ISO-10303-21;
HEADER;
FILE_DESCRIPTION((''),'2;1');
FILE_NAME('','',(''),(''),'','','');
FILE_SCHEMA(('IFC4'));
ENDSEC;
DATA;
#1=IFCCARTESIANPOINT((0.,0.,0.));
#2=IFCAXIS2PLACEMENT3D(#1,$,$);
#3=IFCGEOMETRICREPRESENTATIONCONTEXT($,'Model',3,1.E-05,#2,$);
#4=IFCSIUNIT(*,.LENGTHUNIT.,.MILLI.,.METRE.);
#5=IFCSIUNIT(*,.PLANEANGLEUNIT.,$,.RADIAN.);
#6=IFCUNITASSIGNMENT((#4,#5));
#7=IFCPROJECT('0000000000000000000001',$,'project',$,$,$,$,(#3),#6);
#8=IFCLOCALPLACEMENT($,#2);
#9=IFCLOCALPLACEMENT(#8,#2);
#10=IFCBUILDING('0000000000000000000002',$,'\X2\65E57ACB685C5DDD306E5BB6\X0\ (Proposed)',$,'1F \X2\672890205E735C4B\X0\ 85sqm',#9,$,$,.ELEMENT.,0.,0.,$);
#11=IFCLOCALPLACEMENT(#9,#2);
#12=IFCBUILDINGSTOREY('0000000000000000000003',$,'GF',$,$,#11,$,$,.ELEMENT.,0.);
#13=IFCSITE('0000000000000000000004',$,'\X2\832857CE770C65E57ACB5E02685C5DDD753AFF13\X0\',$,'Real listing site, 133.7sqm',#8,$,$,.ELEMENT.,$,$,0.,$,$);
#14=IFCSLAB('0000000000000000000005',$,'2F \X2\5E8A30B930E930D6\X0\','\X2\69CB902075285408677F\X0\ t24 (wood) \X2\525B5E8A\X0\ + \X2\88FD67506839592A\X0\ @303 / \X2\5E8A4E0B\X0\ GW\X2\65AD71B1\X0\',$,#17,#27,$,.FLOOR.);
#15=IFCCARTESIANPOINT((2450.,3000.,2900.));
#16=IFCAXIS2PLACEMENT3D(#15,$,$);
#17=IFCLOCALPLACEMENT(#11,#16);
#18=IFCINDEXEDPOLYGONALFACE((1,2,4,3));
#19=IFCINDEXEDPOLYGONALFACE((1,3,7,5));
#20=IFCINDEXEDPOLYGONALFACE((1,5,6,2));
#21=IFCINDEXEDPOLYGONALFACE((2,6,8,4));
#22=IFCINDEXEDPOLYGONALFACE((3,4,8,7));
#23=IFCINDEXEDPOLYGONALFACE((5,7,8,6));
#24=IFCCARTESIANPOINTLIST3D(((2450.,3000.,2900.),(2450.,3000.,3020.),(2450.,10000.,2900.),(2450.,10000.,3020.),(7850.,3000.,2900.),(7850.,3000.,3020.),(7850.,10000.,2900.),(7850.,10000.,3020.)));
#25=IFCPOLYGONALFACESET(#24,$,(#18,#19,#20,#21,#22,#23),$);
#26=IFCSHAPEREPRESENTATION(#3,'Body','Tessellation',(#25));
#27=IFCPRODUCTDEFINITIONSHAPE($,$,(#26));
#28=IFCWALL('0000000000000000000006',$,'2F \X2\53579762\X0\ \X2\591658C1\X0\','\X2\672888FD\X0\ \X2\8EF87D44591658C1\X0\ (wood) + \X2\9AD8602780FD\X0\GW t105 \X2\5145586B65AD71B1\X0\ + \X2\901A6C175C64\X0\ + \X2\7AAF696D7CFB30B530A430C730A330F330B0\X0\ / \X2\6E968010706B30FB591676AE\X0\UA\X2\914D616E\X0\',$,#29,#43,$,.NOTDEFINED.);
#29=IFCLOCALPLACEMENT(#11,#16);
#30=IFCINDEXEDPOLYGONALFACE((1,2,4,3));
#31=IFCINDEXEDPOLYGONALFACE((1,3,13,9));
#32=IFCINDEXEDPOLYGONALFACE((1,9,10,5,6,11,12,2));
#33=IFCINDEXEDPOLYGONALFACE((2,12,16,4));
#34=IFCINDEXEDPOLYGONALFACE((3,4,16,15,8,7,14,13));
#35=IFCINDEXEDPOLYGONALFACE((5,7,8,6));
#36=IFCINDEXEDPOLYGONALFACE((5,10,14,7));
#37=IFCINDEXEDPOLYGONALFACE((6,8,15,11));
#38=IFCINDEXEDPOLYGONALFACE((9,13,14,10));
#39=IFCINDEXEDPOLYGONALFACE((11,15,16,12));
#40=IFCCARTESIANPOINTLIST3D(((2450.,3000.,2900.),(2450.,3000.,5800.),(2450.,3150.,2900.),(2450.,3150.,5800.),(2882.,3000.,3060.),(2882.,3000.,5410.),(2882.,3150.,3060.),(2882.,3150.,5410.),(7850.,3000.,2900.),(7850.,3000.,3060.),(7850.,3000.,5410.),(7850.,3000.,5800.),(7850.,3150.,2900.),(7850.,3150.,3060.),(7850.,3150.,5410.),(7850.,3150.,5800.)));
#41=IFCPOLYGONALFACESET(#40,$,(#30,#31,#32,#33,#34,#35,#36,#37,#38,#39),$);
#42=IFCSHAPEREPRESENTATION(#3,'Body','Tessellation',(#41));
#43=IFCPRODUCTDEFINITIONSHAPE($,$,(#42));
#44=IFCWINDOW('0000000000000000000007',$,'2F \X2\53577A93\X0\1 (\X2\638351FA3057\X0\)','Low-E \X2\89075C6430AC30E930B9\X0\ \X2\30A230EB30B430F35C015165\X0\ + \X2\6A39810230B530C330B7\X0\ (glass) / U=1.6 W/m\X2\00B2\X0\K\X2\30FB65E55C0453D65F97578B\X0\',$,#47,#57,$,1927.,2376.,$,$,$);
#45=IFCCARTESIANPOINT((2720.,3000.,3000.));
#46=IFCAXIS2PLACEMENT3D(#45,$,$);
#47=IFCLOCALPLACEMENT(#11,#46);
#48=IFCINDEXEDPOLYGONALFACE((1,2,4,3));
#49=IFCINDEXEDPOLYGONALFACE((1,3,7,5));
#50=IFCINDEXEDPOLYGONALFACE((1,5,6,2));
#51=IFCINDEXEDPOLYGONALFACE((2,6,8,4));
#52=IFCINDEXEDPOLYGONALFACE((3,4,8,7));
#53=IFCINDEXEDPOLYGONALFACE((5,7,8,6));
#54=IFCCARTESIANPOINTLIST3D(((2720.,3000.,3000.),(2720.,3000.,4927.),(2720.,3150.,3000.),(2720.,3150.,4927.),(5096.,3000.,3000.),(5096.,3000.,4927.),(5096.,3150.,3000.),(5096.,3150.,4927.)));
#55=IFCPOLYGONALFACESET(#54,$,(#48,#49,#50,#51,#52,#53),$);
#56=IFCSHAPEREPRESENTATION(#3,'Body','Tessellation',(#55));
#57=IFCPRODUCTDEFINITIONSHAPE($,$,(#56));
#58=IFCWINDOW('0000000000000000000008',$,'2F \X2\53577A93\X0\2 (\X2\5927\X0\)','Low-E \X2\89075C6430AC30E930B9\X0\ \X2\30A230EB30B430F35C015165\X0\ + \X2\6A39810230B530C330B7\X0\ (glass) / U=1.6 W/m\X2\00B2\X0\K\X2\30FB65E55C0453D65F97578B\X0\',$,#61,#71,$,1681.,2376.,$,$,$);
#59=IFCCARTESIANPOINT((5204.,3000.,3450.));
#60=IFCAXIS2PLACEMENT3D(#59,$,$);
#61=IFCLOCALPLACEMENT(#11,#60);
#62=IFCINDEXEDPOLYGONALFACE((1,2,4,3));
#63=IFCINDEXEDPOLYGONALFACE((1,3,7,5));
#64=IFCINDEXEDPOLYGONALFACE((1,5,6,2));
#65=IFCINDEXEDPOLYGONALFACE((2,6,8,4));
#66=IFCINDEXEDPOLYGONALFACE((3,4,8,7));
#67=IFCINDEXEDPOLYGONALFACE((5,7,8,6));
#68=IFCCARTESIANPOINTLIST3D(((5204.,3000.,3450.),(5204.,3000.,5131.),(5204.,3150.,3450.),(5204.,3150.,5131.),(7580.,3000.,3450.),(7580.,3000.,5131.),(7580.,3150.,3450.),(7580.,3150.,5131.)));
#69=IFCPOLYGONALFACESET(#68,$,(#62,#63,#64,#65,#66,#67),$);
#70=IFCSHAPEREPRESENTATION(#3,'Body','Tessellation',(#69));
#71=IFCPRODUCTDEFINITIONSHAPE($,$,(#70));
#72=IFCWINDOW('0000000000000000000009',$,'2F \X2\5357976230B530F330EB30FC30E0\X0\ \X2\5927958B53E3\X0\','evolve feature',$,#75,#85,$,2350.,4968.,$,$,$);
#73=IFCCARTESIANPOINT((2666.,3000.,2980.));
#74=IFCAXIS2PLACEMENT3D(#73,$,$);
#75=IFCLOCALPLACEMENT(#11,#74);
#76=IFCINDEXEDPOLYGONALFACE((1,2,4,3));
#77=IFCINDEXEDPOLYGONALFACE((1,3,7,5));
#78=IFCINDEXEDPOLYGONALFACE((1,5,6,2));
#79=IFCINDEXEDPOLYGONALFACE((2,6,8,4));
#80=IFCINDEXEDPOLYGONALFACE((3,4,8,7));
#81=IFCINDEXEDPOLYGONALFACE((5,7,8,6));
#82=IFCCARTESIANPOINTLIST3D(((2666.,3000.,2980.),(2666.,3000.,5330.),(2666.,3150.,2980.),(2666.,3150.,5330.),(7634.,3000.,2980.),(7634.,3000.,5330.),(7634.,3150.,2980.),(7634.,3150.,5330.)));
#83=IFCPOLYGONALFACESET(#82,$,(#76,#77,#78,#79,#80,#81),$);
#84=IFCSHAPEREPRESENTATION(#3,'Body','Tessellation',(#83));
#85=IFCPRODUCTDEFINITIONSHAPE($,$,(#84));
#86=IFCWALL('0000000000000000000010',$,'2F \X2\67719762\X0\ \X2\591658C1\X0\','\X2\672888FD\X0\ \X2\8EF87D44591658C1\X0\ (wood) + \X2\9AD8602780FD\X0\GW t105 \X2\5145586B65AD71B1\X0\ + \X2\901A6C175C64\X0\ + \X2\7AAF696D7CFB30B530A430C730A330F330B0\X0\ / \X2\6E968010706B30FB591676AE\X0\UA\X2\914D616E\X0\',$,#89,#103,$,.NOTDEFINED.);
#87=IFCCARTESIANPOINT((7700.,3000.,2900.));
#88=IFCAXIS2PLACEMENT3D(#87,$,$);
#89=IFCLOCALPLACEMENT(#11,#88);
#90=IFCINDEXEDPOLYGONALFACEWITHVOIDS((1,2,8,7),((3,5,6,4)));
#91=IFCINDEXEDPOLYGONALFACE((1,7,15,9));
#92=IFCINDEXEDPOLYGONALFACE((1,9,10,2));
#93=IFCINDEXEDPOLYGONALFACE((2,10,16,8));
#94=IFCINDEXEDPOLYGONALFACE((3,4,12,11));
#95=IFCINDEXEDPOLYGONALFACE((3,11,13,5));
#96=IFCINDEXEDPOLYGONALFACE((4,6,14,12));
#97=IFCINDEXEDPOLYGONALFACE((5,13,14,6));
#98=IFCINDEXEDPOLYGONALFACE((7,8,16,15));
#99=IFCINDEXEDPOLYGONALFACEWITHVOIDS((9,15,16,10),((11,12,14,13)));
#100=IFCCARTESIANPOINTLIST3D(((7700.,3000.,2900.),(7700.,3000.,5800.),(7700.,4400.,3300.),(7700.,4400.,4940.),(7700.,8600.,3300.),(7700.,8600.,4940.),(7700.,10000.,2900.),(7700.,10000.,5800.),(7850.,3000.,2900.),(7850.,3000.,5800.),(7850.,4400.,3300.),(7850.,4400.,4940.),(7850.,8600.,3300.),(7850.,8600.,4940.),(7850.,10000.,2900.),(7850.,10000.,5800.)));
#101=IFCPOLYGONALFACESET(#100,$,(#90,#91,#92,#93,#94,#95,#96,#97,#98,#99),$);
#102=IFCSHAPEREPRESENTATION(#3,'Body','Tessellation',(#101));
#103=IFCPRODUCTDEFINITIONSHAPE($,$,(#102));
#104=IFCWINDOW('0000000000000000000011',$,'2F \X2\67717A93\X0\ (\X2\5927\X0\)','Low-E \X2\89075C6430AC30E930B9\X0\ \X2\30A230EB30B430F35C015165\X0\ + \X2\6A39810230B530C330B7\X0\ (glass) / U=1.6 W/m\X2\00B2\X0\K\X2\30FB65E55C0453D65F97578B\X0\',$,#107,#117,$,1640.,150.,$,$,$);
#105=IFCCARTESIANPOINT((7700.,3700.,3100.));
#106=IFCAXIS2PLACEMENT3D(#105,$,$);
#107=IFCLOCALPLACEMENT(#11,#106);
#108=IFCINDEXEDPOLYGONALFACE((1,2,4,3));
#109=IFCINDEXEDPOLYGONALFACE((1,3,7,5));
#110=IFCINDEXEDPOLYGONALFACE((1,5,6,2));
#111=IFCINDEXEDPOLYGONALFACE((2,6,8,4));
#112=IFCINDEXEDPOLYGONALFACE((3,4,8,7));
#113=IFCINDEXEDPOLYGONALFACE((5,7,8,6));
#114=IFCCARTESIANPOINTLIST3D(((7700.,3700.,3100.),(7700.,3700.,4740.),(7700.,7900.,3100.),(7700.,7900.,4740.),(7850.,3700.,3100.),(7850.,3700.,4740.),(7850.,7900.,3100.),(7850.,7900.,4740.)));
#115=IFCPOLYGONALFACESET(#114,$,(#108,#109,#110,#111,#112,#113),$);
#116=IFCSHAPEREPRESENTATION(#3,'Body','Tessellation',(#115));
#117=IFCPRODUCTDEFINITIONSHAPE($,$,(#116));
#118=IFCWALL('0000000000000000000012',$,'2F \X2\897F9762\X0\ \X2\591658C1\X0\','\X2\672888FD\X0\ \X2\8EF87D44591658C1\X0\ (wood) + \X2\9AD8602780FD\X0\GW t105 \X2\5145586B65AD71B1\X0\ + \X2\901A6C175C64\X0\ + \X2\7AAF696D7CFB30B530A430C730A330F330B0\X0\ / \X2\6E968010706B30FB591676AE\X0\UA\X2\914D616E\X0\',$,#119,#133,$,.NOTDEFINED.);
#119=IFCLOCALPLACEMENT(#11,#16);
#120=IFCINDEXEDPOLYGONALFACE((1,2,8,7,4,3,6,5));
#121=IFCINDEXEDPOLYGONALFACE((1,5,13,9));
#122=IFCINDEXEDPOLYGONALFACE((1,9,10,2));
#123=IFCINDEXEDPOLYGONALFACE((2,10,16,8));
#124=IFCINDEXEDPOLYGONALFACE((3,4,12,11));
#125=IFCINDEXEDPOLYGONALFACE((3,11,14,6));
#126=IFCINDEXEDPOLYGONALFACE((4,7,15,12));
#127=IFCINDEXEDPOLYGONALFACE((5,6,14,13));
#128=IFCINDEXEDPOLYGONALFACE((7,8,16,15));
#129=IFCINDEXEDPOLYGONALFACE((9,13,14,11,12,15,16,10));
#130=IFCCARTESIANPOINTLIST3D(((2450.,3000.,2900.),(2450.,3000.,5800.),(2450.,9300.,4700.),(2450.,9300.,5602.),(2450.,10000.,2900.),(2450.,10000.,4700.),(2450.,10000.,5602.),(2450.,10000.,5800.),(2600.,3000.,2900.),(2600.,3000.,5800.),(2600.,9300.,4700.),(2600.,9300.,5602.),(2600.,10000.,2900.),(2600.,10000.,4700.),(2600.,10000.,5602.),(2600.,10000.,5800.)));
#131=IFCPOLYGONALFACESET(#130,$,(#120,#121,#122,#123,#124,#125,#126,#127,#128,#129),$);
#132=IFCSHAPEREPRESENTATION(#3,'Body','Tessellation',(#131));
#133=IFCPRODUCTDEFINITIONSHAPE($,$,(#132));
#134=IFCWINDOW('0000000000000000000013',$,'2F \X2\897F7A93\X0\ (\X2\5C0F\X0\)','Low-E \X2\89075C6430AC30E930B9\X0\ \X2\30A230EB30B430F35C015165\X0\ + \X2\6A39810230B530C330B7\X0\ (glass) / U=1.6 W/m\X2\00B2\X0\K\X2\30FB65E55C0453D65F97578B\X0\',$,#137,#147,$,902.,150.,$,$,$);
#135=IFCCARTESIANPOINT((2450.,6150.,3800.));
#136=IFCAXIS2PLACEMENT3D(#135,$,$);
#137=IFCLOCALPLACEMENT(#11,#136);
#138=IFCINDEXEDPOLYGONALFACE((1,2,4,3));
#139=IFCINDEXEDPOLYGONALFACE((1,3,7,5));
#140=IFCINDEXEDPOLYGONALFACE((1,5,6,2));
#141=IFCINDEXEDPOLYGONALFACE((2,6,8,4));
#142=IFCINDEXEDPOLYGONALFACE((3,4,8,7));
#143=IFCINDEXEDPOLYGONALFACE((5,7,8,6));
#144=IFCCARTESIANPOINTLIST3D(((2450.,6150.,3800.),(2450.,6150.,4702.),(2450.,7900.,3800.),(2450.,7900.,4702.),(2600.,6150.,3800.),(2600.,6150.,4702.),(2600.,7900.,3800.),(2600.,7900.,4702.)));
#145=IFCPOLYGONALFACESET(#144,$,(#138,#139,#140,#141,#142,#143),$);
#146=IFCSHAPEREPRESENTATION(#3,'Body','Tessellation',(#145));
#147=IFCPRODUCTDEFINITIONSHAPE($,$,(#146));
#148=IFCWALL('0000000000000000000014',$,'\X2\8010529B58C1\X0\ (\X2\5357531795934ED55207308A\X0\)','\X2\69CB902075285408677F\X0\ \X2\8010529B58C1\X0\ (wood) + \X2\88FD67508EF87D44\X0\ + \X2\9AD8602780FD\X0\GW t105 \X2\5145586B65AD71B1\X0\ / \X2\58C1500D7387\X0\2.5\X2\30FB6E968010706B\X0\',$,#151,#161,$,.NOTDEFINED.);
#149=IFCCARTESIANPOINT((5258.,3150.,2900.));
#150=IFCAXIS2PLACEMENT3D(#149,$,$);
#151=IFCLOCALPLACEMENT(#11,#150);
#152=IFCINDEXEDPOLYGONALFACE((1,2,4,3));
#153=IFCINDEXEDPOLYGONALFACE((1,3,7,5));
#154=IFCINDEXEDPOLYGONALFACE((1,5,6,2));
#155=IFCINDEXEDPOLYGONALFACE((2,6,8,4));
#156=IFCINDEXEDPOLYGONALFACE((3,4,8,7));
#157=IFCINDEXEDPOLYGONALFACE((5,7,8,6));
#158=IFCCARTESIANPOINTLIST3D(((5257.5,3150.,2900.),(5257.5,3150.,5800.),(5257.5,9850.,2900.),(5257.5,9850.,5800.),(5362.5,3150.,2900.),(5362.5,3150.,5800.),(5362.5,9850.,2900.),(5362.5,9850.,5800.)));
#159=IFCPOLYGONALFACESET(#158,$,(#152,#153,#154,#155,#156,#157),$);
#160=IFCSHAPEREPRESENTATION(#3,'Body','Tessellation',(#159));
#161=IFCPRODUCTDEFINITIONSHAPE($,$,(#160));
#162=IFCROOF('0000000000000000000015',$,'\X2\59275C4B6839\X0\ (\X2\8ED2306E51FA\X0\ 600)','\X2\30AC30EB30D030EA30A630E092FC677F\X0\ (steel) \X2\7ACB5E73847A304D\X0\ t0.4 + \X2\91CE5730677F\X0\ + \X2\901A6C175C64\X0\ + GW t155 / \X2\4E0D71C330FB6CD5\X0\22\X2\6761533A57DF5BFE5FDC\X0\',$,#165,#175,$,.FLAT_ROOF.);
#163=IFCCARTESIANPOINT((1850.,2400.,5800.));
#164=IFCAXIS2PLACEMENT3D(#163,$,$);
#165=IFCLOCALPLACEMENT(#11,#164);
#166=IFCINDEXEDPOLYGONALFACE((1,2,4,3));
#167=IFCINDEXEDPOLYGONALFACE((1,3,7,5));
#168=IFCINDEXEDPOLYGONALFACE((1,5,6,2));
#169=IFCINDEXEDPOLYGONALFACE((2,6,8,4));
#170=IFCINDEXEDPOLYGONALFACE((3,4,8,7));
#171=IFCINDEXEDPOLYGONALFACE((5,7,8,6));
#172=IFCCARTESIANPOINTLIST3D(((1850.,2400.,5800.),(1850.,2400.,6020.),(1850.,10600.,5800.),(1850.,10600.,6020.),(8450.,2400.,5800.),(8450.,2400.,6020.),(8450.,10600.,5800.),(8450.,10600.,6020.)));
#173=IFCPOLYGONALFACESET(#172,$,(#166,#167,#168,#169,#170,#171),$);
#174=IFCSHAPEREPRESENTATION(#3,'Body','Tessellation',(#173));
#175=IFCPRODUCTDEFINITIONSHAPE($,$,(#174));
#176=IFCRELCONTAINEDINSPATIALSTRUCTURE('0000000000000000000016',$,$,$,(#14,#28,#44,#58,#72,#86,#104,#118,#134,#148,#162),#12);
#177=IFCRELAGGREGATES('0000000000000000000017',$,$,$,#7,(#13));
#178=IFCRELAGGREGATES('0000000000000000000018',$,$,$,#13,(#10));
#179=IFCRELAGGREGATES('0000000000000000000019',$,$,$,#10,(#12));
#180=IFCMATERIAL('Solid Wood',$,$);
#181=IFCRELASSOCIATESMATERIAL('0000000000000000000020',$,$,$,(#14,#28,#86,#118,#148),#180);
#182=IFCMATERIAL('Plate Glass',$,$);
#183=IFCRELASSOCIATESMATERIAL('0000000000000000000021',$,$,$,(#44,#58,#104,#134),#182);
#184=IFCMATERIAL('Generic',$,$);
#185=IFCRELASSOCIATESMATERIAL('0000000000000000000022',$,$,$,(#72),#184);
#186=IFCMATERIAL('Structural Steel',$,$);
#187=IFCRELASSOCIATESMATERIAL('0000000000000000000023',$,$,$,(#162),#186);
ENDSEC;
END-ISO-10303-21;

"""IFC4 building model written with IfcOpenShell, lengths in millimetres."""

from ifc_helpers import new_model, si_unit, frame, frame_2d, origin, place, context, project, spatial, rectangle, extrude, material, element, fill, save


model = new_model("IFC4")

# Units and contexts
model_context = context("Model", 3, precision=1e-05, world=origin())
ifc_project = project(units=[si_unit("LENGTHUNIT", "METRE", prefix="MILLI"), si_unit("PLANEANGLEUNIT", "RADIAN")], contexts=[model_context])

# Site, building, storey
site_placement = place(None, origin())
site = spatial("IfcSite", under=ifc_project, at=site_placement, Name="茨城県日立市桜川町３", ObjectType="Real listing site, 133.7sqm", CompositionType="ELEMENT", RefElevation=0.0)
building_placement = place(site_placement, origin())
building = spatial("IfcBuilding", under=site, at=building_placement, Name="日立桜川の家 (Proposed)", ObjectType="1F 木造平屋 85sqm", CompositionType="ELEMENT", ElevationOfRefHeight=0.0, ElevationOfTerrain=0.0)
storey_placement = place(building_placement, origin())
storey = spatial("IfcBuildingStorey", under=building, at=storey_placement, Name="GF", CompositionType="ELEMENT", Elevation=0.0)

# Slab
ifc_material_1 = material(Name="Solid Wood")
slab_placement = place(storey_placement, frame((2450.0, 3000.0, 2900.0)))
element("IfcSlab", 1, at=slab_placement, inside=storey, material=ifc_material_1, Name="2F 床スラブ", Description="構造用合板 t24 (wood) 剛床 + 製材根太 @303 / 床下 GW断熱", PredefinedType="FLOOR", context=model_context, shape_type="SweptSolid", body=[
    extrude(rectangle(XDim=5400.0, YDim=7000.0, at=frame_2d((2700.0, 3500.0))), frame((2450.0, 3000.0, 2900.0)), (0.0, 0.0, 1.0), 120.0),
])

# Wall, openings, windows
wall_1_placement = place(storey_placement, frame((2450.0, 3000.0, 2900.0)))
wall_1 = element("IfcWall", 2, at=wall_1_placement, inside=storey, material=ifc_material_1, Name="2F 南面 外壁", Description="木製 軸組外壁 (wood) + 高性能GW t105 充填断熱 + 通気層 + 窯業系サイディング / 準耐火・外皮UA配慮", PredefinedType="NOTDEFINED", context=model_context, shape_type="SweptSolid", body=[
    extrude(rectangle(XDim=5400.0, YDim=150.0, at=frame_2d((2700.0, 75.0))), frame((2450.0, 3000.0, 2900.0)), (0.0, 0.0, 1.0), 2900.0),
])
opening_1_placement = place(storey_placement, frame((2720.0, 3000.0, 3000.0)))
opening_1 = element("IfcOpeningElement", 3, at=opening_1_placement, cuts=wall_1, PredefinedType="NOTDEFINED", context=model_context, shape_type="SweptSolid", body=[
    extrude(rectangle(XDim=2376.0, YDim=150.0, at=frame_2d((1188.0, 75.0))), frame((2720.0, 3000.0, 3000.0)), (0.0, 0.0, 1.0), 1927.0),
])
opening_2_placement = place(storey_placement, frame((5204.0, 3000.0, 3450.0)))
opening_2 = element("IfcOpeningElement", 4, at=opening_2_placement, cuts=wall_1, PredefinedType="NOTDEFINED", context=model_context, shape_type="SweptSolid", body=[
    extrude(rectangle(XDim=2376.0, YDim=150.0, at=frame_2d((1188.0, 75.0))), frame((5204.0, 3000.0, 3450.0)), (0.0, 0.0, 1.0), 1681.0),
])
opening_3_placement = place(storey_placement, frame((2666.0, 3000.0, 2980.0)))
opening_3 = element("IfcOpeningElement", 5, at=opening_3_placement, cuts=wall_1, PredefinedType="NOTDEFINED", context=model_context, shape_type="SweptSolid", body=[
    extrude(rectangle(XDim=4968.0, YDim=150.0, at=frame_2d((2484.0, 75.0))), frame((2666.0, 3000.0, 2980.0)), (0.0, 0.0, 1.0), 2350.0),
])
ifc_material_2 = material(Name="Plate Glass")
window_1_placement = place(storey_placement, frame((2720.0, 3000.0, 3000.0)))
window_1 = element("IfcWindow", 6, at=window_1_placement, inside=storey, material=ifc_material_2, Name="2F 南窓1 (掃出し)", Description="Low-E 複層ガラス アルゴン封入 + 樹脂サッシ (glass) / U=1.6 W/m²K・日射取得型", OverallHeight=1927.0, OverallWidth=2376.0, context=model_context, shape_type="SweptSolid", body=[
    extrude(rectangle(XDim=2376.0, YDim=150.0, at=frame_2d((1188.0, 75.0))), frame((2720.0, 3000.0, 3000.0)), (0.0, 0.0, 1.0), 1927.0),
])
fill(opening_1, window_1)
window_2_placement = place(storey_placement, frame((5204.0, 3000.0, 3450.0)))
window_2 = element("IfcWindow", 7, at=window_2_placement, inside=storey, material=ifc_material_2, Name="2F 南窓2 (大)", Description="Low-E 複層ガラス アルゴン封入 + 樹脂サッシ (glass) / U=1.6 W/m²K・日射取得型", OverallHeight=1681.0, OverallWidth=2376.0, context=model_context, shape_type="SweptSolid", body=[
    extrude(rectangle(XDim=2376.0, YDim=150.0, at=frame_2d((1188.0, 75.0))), frame((5204.0, 3000.0, 3450.0)), (0.0, 0.0, 1.0), 1681.0),
])
fill(opening_2, window_2)
ifc_material_3 = material(Name="Generic")
window_3_placement = place(storey_placement, frame((2666.0, 3000.0, 2980.0)))
window_3 = element("IfcWindow", 8, at=window_3_placement, inside=storey, material=ifc_material_3, Name="2F 南面サンルーム 大開口", Description="evolve feature", OverallHeight=2350.0, OverallWidth=4968.0, context=model_context, shape_type="SweptSolid", body=[
    extrude(rectangle(XDim=4968.0, YDim=150.0, at=frame_2d((2484.0, 75.0))), frame((2666.0, 3000.0, 2980.0)), (0.0, 0.0, 1.0), 2350.0),
])
fill(opening_3, window_3)

# Walls, openings, windows
wall_2_placement = place(storey_placement, frame((7700.0, 3000.0, 2900.0)))
wall_2 = element("IfcWall", 9, at=wall_2_placement, inside=storey, material=ifc_material_1, Name="2F 東面 外壁", Description="木製 軸組外壁 (wood) + 高性能GW t105 充填断熱 + 通気層 + 窯業系サイディング / 準耐火・外皮UA配慮", PredefinedType="NOTDEFINED", context=model_context, shape_type="SweptSolid", body=[
    extrude(rectangle(XDim=150.0, YDim=7000.0, at=frame_2d((75.0, 3500.0))), frame((7700.0, 3000.0, 2900.0)), (0.0, 0.0, 1.0), 2900.0),
])
opening_4_placement = place(storey_placement, frame((7700.0, 3700.0, 3100.0)))
opening_4 = element("IfcOpeningElement", 10, at=opening_4_placement, cuts=wall_2, PredefinedType="NOTDEFINED", context=model_context, shape_type="SweptSolid", body=[
    extrude(rectangle(XDim=150.0, YDim=4200.0, at=frame_2d((75.0, 2100.0))), frame((7700.0, 3700.0, 3100.0)), (0.0, 0.0, 1.0), 1640.0),
])
window_4_placement = place(storey_placement, frame((7700.0, 3700.0, 3100.0)))
window_4 = element("IfcWindow", 11, at=window_4_placement, inside=storey, material=ifc_material_2, Name="2F 東窓 (大)", Description="Low-E 複層ガラス アルゴン封入 + 樹脂サッシ (glass) / U=1.6 W/m²K・日射取得型", OverallHeight=1640.0, OverallWidth=150.0, context=model_context, shape_type="SweptSolid", body=[
    extrude(rectangle(XDim=150.0, YDim=4200.0, at=frame_2d((75.0, 2100.0))), frame((7700.0, 3700.0, 3100.0)), (0.0, 0.0, 1.0), 1640.0),
])
fill(opening_4, window_4)
wall_3_placement = place(storey_placement, frame((2450.0, 3000.0, 2900.0)))
wall_3 = element("IfcWall", 12, at=wall_3_placement, inside=storey, material=ifc_material_1, Name="2F 西面 外壁", Description="木製 軸組外壁 (wood) + 高性能GW t105 充填断熱 + 通気層 + 窯業系サイディング / 準耐火・外皮UA配慮", PredefinedType="NOTDEFINED", context=model_context, shape_type="SweptSolid", body=[
    extrude(rectangle(XDim=150.0, YDim=7000.0, at=frame_2d((75.0, 3500.0))), frame((2450.0, 3000.0, 2900.0)), (0.0, 0.0, 1.0), 2900.0),
])
opening_5_placement = place(storey_placement, frame((2450.0, 6150.0, 3800.0)))
opening_5 = element("IfcOpeningElement", 13, at=opening_5_placement, cuts=wall_3, PredefinedType="NOTDEFINED", context=model_context, shape_type="SweptSolid", body=[
    extrude(rectangle(XDim=150.0, YDim=1750.0, at=frame_2d((75.0, 875.0))), frame((2450.0, 6150.0, 3800.0)), (0.0, 0.0, 1.0), 902.0),
])
window_5_placement = place(storey_placement, frame((2450.0, 6150.0, 3800.0)))
window_5 = element("IfcWindow", 14, at=window_5_placement, inside=storey, material=ifc_material_2, Name="2F 西窓 (小)", Description="Low-E 複層ガラス アルゴン封入 + 樹脂サッシ (glass) / U=1.6 W/m²K・日射取得型", OverallHeight=902.0, OverallWidth=150.0, context=model_context, shape_type="SweptSolid", body=[
    extrude(rectangle(XDim=150.0, YDim=1750.0, at=frame_2d((75.0, 875.0))), frame((2450.0, 6150.0, 3800.0)), (0.0, 0.0, 1.0), 902.0),
])
fill(opening_5, window_5)

# Wall
wall_4_placement = place(storey_placement, frame((5258.0, 3150.0, 2900.0)))
element("IfcWall", 15, at=wall_4_placement, inside=storey, material=ifc_material_1, Name="耐力壁 (南北間仕切り)", Description="構造用合板 耐力壁 (wood) + 製材軸組 + 高性能GW t105 充填断熱 / 壁倍率2.5・準耐火", PredefinedType="NOTDEFINED", context=model_context, shape_type="SweptSolid", body=[
    extrude(rectangle(XDim=105.0, YDim=6700.0, at=frame_2d((52.0, 3350.0))), frame((5258.0, 3150.0, 2900.0)), (0.0, 0.0, 1.0), 2900.0),
])

# Roof
ifc_material_4 = material(Name="Structural Steel")
roof_1_placement = place(storey_placement, frame((1850.0, 2400.0, 5800.0)))
element("IfcRoof", 16, at=roof_1_placement, inside=storey, material=ifc_material_4, Name="大屋根 (軒の出 600)", Description="ガルバリウム鋼板 (steel) 立平葺き t0.4 + 野地板 + 通気層 + GW t155 / 不燃・法22条区域対応", PredefinedType="FLAT_ROOF", context=model_context, shape_type="SweptSolid", body=[
    extrude(rectangle(XDim=6600.0, YDim=8200.0, at=frame_2d((3300.0, 4100.0))), frame((1850.0, 2400.0, 5800.0)), (0.0, 0.0, 1.0), 220.0),
])

save(model, "model.ifc")
